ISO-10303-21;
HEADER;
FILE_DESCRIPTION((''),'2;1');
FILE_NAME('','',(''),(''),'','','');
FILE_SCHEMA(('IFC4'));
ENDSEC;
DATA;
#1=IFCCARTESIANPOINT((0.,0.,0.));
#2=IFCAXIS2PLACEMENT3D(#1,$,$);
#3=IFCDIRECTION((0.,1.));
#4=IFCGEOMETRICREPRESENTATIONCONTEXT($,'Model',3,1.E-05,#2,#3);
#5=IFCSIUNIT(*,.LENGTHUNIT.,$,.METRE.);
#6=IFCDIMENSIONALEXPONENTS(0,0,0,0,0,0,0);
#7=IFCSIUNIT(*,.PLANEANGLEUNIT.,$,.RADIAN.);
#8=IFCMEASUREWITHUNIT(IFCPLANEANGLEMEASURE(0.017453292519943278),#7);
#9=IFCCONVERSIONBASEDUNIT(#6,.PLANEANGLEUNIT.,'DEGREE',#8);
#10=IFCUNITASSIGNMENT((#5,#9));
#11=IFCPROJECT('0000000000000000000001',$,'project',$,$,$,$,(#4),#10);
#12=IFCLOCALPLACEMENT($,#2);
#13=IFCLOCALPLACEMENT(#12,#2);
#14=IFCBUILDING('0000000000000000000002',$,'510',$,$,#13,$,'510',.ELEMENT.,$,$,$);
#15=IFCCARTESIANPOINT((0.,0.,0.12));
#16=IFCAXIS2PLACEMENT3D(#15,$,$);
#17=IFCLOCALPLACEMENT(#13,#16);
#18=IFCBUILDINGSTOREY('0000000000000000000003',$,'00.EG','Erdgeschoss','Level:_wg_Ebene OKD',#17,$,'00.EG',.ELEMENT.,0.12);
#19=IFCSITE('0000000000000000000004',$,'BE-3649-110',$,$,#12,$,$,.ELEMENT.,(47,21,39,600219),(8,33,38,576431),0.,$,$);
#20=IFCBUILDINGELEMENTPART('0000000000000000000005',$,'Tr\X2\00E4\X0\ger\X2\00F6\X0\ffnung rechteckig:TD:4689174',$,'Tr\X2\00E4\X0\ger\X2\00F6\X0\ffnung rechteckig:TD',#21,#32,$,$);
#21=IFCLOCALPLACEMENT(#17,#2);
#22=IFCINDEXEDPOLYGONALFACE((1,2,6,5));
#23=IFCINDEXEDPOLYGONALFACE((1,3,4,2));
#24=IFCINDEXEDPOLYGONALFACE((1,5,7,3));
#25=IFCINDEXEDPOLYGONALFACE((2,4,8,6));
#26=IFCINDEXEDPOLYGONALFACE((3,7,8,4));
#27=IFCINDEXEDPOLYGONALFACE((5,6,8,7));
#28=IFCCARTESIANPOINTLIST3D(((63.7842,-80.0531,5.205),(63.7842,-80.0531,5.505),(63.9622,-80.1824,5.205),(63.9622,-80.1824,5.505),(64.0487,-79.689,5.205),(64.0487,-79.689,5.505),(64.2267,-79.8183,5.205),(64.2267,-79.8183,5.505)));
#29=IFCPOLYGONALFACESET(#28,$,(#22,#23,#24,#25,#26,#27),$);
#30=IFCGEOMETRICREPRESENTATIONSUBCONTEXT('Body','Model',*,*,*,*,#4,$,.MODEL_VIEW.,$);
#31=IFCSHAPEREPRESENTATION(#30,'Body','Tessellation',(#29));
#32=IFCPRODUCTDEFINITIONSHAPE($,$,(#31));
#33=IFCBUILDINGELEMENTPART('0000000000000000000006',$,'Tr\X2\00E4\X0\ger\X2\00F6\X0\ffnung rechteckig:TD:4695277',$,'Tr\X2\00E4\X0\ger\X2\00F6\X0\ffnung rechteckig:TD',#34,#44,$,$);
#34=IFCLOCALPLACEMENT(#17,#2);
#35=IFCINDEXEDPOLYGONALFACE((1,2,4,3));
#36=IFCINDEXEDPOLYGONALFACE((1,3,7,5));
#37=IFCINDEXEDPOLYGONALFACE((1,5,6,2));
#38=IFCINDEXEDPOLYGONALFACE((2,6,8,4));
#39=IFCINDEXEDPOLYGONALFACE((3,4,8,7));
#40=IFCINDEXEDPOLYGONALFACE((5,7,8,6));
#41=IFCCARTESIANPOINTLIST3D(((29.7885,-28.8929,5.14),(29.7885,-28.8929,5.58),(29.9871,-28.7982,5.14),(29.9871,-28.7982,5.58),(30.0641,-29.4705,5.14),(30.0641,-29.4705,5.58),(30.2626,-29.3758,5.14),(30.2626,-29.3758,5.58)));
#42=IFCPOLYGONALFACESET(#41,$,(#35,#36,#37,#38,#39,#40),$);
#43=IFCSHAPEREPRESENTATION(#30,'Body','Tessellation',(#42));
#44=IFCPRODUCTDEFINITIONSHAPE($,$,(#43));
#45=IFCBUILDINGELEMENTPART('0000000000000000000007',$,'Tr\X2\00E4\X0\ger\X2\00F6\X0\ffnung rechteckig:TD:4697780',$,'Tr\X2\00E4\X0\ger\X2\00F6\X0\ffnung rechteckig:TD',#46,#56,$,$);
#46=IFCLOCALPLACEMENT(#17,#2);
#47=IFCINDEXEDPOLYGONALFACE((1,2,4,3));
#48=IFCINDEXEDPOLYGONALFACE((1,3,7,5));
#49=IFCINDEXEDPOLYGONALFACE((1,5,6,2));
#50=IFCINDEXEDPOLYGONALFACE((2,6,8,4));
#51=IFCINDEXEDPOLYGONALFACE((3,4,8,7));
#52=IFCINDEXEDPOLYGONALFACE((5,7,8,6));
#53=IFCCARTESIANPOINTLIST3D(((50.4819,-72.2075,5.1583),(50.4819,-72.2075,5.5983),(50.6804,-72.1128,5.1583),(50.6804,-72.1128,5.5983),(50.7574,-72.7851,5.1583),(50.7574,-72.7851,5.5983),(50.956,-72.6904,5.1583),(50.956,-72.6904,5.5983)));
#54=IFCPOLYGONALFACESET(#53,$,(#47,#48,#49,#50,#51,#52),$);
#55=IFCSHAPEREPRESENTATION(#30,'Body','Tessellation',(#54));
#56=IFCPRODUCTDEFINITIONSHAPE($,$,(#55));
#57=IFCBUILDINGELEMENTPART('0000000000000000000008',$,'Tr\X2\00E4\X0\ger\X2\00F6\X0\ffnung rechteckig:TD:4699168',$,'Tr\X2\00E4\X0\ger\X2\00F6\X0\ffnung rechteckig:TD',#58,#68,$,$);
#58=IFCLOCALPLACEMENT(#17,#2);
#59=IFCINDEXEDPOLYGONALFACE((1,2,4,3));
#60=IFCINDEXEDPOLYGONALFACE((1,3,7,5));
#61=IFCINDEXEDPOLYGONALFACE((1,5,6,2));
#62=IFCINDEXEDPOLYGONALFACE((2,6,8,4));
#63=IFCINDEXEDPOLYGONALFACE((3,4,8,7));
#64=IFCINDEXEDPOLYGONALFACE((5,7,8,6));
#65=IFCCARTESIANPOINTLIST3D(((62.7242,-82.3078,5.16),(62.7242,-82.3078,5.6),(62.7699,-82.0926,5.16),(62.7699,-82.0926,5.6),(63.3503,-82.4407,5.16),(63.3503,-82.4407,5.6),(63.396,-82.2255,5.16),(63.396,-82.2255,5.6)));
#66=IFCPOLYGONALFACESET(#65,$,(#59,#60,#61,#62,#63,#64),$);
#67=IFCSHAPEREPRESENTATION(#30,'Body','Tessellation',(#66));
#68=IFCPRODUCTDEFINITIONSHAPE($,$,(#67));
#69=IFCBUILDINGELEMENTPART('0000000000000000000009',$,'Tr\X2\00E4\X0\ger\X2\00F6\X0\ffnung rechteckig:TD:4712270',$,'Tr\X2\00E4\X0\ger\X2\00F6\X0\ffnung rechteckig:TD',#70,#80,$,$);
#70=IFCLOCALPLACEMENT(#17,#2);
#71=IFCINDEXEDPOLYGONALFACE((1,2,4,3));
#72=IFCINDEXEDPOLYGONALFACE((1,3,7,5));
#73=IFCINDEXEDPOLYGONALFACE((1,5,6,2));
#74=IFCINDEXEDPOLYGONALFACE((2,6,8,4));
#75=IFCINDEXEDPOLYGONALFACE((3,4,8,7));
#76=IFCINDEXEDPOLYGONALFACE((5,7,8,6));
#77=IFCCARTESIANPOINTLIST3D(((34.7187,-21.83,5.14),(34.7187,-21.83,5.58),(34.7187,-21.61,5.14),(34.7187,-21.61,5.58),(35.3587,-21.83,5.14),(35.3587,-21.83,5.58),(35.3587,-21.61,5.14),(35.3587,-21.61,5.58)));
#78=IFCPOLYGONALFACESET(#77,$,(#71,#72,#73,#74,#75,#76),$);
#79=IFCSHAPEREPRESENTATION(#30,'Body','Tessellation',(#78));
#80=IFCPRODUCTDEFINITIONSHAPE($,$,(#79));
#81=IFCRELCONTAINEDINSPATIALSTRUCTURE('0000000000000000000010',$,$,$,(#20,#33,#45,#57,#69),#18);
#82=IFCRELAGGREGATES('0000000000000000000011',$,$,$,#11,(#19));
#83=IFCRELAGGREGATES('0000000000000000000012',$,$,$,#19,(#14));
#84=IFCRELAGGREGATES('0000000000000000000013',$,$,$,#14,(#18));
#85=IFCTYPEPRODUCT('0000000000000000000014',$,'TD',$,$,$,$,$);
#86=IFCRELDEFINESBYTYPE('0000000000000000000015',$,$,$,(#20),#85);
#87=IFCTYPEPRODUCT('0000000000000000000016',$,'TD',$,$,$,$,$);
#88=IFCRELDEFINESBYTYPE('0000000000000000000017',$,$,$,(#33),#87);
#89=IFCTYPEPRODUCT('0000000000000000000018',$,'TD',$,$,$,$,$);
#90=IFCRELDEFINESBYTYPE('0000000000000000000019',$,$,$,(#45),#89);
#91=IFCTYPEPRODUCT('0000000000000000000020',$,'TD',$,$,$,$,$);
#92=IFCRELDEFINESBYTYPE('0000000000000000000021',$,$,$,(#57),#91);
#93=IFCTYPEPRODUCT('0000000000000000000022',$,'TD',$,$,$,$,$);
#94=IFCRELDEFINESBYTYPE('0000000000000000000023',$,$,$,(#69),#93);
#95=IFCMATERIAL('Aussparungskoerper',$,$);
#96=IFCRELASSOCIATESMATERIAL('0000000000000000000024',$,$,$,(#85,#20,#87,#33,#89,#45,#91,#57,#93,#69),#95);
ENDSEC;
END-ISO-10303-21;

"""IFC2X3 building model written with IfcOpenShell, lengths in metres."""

from ifc_helpers import new_model, entity, si_unit, converted_unit, direction, frame, frame_2d, origin, origin_2d_with_axis, place, context, subcontext, project, spatial, rectangle, extrude, source, transform, mapped, material, type_object, type_shapes, element, save


model = new_model("IFC2X3")

# Units and contexts
model_context = context("Model", 3, precision=1e-05, world=origin(), true_north=direction((0.0, 1.0)))
body_context = subcontext(model_context, "Body", "Model", "MODEL_VIEW")
ifc_project = project(units=[si_unit("LENGTHUNIT", "METRE"), converted_unit("PLANEANGLEUNIT", "DEGREE", entity("IfcPlaneAngleMeasure", 0.017453292519943278), si_unit("PLANEANGLEUNIT", "RADIAN"), dimensions=[0, 0, 0, 0, 0, 0, 0])], contexts=[model_context])

# Site, building, storey
site_placement = place(None, origin())
site = spatial("IfcSite", under=ifc_project, at=site_placement, Name="BE-3649-110", CompositionType="ELEMENT", RefLatitude=(47, 21, 39, 600219), RefLongitude=(8, 33, 38, 576431), RefElevation=0.0)
building_placement = place(site_placement, origin())
building = spatial("IfcBuilding", under=site, at=building_placement, Name="510", LongName="510", CompositionType="ELEMENT")
storey_placement = place(building_placement, frame((0.0, 0.0, 0.12)))
storey = spatial("IfcBuildingStorey", under=building, at=storey_placement, Name="00.EG", Description="Erdgeschoss", ObjectType="Level:_wg_Ebene OKD", LongName="00.EG", CompositionType="ELEMENT", Elevation=0.12)

# Building element parts
ifc_material_1 = material(Name="Aussparungskoerper")
type_product_1 = type_object("IfcTypeProduct", Name="TD", material=ifc_material_1)
shared_shape_1 = source(origin(), body_context, "Body", "SweptSolid", [
    extrude(rectangle(XDim=0.45, YDim=0.3, at=origin_2d_with_axis()), frame((0.0, 0.0, -0.22), z_axis=(0.0, 0.0, 1.0), x_axis=(-1.0, 0.0, 0.0)), (0.0, 0.0, 1.0), 0.22),
])
type_shapes(type_product_1, [shared_shape_1])
for number, where, z_axis, x_axis, name in (
    (1, (64.0944, -80.0003, 5.355), (0.809017, -0.587785, 0.0), (-0.587785, -0.809017, 0.0), "Trägeröffnung rechteckig:TD:4689174"),
):
    element("IfcBuildingElementPart", number, at=place(storey_placement, frame(where, z_axis=z_axis, x_axis=x_axis)), inside=storey, type_object=type_product_1, material=ifc_material_1, Name=name, ObjectType="Trägeröffnung rechteckig:TD", context=body_context, shape_type="MappedRepresentation", body=[
        mapped(shared_shape_1, transform((0.0, 0.0, 0.0), scale=1.0)),
    ])
type_product_2 = type_object("IfcTypeProduct", Name="TD", material=ifc_material_1)
shared_shape_2 = source(origin(), body_context, "Body", "SweptSolid", [
    extrude(rectangle(XDim=0.22, YDim=0.64, at=frame_2d((0.0, 0.0), x_axis=(1.0, 0.0))), frame((30.0256, -29.1344, -0.44), z_axis=(0.0, 0.0, 1.0), x_axis=(-0.902585, -0.430511, 0.0)), (0.0, 0.0, 1.0), 0.44),
])
type_shapes(type_product_2, [shared_shape_2])
building_element_part_1_placement = place(storey_placement, frame((0.0, 0.0, 5.58)))
element("IfcBuildingElementPart", 2, at=building_element_part_1_placement, inside=storey, type_object=type_product_2, material=ifc_material_1, Name="Trägeröffnung rechteckig:TD:4695277", ObjectType="Trägeröffnung rechteckig:TD", context=body_context, shape_type="MappedRepresentation", body=[
    mapped(shared_shape_2, transform((0.0, 0.0, 0.0), scale=1.0)),
])
type_product_3 = type_object("IfcTypeProduct", Name="TD", material=ifc_material_1)
shared_shape_3 = source(origin(), body_context, "Body", "SweptSolid", [
    extrude(rectangle(XDim=0.22, YDim=0.64, at=frame_2d((0.0, 0.0), x_axis=(1.0, 0.0))), frame((50.7189, -72.449, -0.44), z_axis=(0.0, 0.0, 1.0), x_axis=(0.902586, 0.43051, 0.0)), (0.0, 0.0, 1.0), 0.44),
])
type_shapes(type_product_3, [shared_shape_3])
building_element_part_2_placement = place(storey_placement, frame((0.0, 0.0, 5.5983)))
element("IfcBuildingElementPart", 3, at=building_element_part_2_placement, inside=storey, type_object=type_product_3, material=ifc_material_1, Name="Trägeröffnung rechteckig:TD:4697780", ObjectType="Trägeröffnung rechteckig:TD", context=body_context, shape_type="MappedRepresentation", body=[
    mapped(shared_shape_3, transform((0.0, 0.0, 0.0), scale=1.0)),
])
type_product_4 = type_object("IfcTypeProduct", Name="TD", material=ifc_material_1)
shared_shape_4 = source(origin(), body_context, "Body", "SweptSolid", [
    extrude(rectangle(XDim=0.44, YDim=0.64, at=origin_2d_with_axis()), frame((0.0, 0.0, -0.22), z_axis=(0.0, 0.0, 1.0), x_axis=(0.0, 1.0, 0.0)), (0.0, 0.0, 1.0), 0.22),
])
type_shapes(type_product_4, [shared_shape_4])
building_element_part_3_placement = place(storey_placement, frame((63.0373, -82.3742, 5.38), z_axis=(-0.207566, -0.978221, 0.0), x_axis=(0.978221, -0.207566, 0.0)))
element("IfcBuildingElementPart", 4, at=building_element_part_3_placement, inside=storey, type_object=type_product_4, material=ifc_material_1, Name="Trägeröffnung rechteckig:TD:4699168", ObjectType="Trägeröffnung rechteckig:TD", context=body_context, shape_type="MappedRepresentation", body=[
    mapped(shared_shape_4, transform((0.0, 0.0, 0.0), scale=1.0)),
])
type_product_5 = type_object("IfcTypeProduct", Name="TD", material=ifc_material_1)
shared_shape_5 = source(origin(), body_context, "Body", "SweptSolid", [
    extrude(rectangle(XDim=0.22, YDim=0.64, at=frame_2d((0.0, 0.0), x_axis=(1.0, 0.0))), frame((35.0387, -21.72, -0.44), z_axis=(0.0, 0.0, 1.0), x_axis=(0.0, 1.0, 0.0)), (0.0, 0.0, 1.0), 0.44),
])
type_shapes(type_product_5, [shared_shape_5])
building_element_part_4_placement = place(storey_placement, frame((0.0, 0.0, 5.58)))
element("IfcBuildingElementPart", 5, at=building_element_part_4_placement, inside=storey, type_object=type_product_5, material=ifc_material_1, Name="Trägeröffnung rechteckig:TD:4712270", ObjectType="Trägeröffnung rechteckig:TD", context=body_context, shape_type="MappedRepresentation", body=[
    mapped(shared_shape_5, transform((0.0, 0.0, 0.0), scale=1.0)),
])

save(model, "model.ifc")
